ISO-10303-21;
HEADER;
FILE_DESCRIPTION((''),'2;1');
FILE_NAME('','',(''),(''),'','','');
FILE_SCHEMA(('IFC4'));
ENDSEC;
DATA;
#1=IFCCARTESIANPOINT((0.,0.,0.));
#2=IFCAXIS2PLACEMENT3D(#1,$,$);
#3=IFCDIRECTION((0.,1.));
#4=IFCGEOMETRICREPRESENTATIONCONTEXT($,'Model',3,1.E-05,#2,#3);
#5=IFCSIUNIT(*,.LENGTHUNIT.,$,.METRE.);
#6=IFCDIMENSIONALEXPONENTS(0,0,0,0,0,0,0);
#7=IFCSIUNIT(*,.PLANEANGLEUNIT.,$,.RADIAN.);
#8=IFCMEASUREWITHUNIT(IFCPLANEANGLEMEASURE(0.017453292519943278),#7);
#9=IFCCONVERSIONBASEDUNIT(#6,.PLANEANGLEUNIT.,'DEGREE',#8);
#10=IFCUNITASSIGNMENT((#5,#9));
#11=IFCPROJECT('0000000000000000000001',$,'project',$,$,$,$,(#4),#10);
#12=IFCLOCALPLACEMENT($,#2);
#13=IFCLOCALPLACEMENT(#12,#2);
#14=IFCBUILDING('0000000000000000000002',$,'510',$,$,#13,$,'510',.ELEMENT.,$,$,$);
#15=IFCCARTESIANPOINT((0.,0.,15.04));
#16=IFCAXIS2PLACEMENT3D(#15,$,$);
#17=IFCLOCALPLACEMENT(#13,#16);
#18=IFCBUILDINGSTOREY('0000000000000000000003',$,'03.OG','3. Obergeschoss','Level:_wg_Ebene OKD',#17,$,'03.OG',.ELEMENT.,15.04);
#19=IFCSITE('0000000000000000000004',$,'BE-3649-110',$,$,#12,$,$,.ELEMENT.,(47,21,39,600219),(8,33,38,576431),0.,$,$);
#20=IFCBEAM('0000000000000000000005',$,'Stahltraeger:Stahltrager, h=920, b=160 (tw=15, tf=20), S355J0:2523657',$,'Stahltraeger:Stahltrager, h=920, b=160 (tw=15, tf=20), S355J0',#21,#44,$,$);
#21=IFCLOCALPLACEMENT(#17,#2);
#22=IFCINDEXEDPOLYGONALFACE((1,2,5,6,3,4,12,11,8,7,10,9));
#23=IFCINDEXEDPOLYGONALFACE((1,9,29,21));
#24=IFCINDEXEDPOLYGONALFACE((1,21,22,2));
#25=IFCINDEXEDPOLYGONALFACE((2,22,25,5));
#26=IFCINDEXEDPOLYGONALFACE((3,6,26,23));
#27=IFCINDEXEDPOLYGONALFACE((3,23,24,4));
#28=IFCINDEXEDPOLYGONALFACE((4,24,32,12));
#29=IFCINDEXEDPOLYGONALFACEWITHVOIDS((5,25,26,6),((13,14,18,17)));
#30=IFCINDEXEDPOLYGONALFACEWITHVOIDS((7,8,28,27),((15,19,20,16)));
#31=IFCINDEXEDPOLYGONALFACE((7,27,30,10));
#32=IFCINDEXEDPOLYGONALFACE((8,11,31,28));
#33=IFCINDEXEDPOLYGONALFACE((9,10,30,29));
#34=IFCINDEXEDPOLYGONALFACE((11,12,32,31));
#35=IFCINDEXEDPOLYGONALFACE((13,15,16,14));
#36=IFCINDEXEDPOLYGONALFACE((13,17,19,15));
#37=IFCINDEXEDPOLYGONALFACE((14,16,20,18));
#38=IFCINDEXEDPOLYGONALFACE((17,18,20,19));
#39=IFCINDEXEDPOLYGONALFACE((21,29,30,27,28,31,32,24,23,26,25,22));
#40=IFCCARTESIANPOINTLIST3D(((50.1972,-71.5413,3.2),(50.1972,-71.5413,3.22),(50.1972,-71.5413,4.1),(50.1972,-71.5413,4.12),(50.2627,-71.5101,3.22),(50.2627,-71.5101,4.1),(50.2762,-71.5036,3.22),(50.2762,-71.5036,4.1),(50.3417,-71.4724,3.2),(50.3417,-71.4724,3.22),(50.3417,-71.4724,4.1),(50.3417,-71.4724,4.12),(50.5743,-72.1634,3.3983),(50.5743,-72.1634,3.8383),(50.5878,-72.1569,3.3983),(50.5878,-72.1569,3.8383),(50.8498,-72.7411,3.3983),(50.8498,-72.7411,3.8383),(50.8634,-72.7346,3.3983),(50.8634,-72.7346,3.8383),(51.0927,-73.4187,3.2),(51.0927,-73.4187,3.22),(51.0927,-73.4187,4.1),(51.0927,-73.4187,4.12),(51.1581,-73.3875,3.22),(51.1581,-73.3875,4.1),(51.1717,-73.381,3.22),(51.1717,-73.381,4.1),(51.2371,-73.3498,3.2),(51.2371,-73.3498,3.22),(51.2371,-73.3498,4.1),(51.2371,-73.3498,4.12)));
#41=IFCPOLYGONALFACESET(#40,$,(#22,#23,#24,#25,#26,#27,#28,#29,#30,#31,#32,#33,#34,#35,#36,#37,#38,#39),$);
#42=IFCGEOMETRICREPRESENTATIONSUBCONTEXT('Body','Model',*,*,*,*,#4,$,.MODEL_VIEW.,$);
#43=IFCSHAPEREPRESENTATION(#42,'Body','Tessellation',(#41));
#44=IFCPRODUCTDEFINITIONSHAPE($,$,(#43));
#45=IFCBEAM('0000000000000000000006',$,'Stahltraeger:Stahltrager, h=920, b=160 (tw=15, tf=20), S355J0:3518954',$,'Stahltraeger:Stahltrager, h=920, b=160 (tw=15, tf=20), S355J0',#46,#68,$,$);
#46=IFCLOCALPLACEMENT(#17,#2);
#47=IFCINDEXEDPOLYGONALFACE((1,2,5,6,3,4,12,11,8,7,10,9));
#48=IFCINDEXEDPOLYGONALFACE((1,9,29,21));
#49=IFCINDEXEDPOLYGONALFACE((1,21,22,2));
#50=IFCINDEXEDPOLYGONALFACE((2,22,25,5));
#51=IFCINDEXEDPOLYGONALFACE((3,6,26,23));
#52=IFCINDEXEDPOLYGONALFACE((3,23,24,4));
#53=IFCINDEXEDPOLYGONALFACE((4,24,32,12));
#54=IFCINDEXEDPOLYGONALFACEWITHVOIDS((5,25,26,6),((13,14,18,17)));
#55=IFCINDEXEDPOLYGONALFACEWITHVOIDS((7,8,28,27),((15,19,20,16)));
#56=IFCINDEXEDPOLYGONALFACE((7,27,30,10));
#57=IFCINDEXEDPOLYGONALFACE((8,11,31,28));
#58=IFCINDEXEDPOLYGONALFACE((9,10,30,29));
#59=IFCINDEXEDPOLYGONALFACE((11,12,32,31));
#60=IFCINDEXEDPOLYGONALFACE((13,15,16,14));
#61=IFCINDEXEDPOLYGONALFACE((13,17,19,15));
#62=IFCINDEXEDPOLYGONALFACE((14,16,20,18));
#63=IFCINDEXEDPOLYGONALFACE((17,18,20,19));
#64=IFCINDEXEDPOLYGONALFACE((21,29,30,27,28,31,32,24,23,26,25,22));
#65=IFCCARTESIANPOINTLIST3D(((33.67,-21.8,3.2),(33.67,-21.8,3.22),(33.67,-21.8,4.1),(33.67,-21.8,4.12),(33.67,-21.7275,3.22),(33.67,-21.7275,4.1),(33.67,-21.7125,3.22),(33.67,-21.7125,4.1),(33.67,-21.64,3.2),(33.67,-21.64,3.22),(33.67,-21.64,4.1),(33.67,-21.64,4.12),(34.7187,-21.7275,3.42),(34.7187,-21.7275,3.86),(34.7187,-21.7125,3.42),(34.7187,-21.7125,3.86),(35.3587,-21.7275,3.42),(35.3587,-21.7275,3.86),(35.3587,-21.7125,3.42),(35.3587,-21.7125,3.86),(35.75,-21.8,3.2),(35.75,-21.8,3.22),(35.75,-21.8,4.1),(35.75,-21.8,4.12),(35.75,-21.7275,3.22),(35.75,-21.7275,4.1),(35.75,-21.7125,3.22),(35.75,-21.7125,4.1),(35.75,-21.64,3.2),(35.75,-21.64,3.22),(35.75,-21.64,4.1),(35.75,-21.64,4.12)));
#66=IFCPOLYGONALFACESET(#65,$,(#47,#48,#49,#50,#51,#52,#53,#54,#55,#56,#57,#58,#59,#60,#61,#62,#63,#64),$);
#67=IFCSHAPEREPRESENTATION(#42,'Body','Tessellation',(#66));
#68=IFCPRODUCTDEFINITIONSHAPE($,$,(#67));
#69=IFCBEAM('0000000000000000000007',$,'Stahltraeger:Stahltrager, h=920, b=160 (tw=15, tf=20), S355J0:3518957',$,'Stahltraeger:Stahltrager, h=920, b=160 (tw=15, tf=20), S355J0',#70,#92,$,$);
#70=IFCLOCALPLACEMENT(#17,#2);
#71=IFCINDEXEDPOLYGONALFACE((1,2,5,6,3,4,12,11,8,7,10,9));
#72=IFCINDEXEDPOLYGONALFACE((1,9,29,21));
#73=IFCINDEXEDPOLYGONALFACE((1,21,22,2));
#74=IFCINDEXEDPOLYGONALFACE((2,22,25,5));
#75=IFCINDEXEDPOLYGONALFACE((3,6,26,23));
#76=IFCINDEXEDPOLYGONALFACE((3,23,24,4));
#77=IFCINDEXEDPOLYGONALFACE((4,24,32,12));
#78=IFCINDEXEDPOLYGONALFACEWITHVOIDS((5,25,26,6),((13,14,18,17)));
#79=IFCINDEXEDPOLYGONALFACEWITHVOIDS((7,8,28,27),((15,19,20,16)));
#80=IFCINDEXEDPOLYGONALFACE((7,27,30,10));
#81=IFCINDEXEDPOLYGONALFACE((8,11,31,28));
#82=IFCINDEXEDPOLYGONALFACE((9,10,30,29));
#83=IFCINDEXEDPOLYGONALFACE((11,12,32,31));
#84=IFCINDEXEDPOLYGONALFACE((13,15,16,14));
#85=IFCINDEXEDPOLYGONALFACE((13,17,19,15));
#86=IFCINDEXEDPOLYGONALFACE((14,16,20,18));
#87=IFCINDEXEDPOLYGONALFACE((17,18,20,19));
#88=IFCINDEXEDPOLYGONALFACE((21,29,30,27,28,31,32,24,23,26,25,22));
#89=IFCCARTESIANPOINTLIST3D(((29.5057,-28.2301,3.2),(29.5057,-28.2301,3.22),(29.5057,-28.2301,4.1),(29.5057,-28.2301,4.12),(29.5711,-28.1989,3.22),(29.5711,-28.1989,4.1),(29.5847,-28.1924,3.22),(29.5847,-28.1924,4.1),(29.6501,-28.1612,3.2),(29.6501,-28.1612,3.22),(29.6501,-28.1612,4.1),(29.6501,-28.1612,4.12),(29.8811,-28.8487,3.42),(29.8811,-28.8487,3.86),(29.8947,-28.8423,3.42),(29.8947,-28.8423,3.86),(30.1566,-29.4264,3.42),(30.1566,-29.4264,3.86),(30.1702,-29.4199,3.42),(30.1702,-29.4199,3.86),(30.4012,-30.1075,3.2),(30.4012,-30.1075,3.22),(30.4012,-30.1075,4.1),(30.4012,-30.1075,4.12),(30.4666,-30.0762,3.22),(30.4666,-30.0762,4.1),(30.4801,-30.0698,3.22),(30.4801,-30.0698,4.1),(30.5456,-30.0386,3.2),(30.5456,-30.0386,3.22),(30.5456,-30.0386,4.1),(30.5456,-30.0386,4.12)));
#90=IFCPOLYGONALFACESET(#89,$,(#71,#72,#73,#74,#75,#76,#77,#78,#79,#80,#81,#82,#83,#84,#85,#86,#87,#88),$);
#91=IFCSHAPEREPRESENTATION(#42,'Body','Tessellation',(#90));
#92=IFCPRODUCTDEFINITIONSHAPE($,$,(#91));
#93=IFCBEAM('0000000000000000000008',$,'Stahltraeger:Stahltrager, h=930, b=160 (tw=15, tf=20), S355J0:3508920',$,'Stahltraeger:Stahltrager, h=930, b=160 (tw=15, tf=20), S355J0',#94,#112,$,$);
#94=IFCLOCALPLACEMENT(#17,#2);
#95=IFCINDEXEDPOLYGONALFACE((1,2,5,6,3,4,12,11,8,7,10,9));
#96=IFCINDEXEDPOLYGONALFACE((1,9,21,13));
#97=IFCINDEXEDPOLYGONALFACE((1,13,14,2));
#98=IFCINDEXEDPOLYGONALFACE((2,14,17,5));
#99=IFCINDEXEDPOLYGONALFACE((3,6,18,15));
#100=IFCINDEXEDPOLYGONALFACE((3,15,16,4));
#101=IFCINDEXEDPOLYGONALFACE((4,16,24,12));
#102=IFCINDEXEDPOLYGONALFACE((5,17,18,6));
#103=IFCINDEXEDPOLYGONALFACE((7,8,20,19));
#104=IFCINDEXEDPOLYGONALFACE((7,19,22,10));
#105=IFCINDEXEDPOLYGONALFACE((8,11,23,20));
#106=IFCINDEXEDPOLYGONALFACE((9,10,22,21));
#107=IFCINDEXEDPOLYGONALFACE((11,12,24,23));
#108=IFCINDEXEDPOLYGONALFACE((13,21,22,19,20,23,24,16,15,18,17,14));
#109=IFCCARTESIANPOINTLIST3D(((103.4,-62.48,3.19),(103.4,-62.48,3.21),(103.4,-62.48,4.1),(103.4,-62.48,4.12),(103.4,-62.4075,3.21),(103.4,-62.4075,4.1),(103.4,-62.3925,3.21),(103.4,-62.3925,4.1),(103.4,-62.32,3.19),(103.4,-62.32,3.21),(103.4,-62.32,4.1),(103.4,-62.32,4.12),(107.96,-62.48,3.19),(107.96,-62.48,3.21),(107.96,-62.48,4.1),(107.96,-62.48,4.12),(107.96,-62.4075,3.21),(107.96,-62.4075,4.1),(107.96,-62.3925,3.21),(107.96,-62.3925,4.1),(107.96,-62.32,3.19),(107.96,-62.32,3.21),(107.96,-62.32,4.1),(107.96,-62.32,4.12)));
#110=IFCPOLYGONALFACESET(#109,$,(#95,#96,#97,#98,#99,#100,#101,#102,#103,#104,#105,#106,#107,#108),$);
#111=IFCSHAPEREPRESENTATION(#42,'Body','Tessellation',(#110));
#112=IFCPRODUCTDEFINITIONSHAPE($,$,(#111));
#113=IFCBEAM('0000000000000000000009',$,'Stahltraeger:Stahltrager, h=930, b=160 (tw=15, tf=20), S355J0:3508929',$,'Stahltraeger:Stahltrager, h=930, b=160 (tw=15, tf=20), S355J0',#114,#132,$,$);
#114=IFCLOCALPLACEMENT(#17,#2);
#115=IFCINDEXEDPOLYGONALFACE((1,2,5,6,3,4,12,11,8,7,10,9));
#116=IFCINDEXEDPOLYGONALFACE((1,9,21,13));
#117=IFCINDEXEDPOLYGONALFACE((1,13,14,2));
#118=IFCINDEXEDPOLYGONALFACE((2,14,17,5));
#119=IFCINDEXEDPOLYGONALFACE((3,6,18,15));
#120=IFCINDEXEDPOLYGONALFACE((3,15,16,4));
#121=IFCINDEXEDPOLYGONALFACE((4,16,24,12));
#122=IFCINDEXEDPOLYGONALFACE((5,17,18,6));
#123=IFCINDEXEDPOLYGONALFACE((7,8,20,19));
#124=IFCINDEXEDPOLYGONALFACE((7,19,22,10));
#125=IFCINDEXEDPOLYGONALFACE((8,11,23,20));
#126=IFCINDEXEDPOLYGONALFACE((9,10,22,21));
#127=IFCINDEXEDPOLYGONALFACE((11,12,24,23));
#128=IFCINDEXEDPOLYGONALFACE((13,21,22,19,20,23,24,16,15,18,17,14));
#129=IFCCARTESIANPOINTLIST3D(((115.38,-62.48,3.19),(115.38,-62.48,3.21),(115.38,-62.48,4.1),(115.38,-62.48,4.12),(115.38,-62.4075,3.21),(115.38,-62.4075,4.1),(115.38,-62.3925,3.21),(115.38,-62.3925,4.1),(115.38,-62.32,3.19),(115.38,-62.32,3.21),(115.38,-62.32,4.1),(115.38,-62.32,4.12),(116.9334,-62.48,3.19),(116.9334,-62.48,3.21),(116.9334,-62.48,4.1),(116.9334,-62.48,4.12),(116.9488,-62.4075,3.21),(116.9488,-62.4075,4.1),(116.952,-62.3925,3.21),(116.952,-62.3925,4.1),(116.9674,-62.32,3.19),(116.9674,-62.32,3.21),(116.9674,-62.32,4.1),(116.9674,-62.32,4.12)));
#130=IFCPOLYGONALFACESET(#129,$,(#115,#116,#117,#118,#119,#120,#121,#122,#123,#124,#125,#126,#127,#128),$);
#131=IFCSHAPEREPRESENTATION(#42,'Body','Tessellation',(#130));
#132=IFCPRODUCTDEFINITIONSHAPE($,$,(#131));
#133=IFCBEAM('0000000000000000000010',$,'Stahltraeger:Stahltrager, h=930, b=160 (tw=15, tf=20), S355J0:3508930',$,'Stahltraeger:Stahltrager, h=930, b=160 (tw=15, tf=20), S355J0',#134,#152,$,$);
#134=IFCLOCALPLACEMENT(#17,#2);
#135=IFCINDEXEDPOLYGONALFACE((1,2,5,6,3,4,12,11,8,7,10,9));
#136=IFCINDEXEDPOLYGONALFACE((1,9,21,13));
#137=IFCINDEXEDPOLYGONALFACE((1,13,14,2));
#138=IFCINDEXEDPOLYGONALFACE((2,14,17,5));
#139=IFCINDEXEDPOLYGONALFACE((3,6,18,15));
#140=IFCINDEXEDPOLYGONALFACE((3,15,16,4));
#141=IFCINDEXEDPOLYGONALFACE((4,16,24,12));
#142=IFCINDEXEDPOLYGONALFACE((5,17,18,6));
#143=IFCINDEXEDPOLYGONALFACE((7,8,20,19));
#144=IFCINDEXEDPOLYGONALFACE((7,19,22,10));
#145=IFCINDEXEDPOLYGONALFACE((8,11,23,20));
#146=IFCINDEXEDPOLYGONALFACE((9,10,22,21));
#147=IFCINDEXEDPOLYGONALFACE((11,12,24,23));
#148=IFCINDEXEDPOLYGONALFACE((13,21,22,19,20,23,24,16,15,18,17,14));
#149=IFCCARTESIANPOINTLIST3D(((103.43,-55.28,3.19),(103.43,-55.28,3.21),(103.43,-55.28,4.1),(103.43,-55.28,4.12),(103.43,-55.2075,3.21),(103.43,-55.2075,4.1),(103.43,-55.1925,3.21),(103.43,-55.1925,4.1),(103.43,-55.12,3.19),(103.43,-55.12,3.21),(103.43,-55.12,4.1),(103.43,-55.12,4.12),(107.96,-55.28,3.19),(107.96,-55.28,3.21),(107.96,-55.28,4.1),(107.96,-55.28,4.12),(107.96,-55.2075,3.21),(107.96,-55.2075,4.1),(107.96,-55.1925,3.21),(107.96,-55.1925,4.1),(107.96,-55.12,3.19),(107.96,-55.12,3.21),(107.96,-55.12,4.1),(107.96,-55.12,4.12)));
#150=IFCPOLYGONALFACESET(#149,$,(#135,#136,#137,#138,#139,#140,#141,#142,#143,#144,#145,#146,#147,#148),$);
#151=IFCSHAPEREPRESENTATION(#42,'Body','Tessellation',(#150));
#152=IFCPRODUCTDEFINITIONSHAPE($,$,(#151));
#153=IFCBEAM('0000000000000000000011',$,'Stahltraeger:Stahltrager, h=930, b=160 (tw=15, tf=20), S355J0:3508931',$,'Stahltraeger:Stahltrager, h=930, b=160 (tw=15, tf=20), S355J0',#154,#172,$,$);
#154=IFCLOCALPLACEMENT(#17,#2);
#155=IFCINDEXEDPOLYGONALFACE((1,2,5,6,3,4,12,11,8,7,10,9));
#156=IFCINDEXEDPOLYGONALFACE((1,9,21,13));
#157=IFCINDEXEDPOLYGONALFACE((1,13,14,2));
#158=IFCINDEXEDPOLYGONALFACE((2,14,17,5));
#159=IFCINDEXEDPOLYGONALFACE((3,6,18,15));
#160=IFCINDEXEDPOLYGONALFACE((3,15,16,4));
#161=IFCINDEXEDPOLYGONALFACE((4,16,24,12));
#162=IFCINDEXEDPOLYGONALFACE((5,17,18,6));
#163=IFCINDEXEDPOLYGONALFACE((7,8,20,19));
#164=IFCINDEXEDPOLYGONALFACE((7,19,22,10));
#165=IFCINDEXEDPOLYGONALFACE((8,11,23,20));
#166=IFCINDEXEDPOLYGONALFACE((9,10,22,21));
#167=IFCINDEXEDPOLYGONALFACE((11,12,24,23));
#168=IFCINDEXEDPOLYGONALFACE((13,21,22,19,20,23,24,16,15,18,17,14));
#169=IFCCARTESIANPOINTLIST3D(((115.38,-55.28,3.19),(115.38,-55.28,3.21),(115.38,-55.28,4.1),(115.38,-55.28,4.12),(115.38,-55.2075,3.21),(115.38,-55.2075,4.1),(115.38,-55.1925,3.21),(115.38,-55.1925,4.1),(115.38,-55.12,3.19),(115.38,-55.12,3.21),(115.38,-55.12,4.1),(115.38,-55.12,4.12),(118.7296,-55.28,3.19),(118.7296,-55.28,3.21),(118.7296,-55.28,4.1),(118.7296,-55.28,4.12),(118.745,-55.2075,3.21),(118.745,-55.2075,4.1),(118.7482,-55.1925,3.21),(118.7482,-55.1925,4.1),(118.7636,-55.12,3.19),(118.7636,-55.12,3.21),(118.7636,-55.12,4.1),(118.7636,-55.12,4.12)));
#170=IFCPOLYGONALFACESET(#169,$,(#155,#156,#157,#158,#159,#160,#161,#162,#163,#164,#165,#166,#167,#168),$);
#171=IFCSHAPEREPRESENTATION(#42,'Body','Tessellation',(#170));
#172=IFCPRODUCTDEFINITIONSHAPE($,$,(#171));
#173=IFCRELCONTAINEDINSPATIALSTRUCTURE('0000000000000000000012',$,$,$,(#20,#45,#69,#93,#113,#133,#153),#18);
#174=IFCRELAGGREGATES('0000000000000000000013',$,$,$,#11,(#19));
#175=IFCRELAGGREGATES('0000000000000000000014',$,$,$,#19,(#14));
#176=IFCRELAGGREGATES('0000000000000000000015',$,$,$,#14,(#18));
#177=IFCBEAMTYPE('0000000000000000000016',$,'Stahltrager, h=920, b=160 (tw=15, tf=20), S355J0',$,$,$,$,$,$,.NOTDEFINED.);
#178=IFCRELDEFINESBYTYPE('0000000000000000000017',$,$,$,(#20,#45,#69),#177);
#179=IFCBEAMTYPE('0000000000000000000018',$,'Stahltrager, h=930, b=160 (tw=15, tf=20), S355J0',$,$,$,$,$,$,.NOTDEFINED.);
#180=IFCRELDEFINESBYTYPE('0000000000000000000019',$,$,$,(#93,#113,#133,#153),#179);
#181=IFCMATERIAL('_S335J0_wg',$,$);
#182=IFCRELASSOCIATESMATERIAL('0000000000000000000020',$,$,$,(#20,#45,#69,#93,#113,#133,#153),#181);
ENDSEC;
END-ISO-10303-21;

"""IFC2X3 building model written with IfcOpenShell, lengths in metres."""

from ifc_helpers import new_model, entity, si_unit, converted_unit, direction, frame, frame_2d, origin, place, context, subcontext, project, spatial, polyline, rectangle, i_section, outline, extrude, boolean, clip, halfspace, material, type_object, element, save


model = new_model("IFC2X3")

# Units and contexts
model_context = context("Model", 3, precision=1e-05, world=origin(), true_north=direction((0.0, 1.0)))
body_context = subcontext(model_context, "Body", "Model", "MODEL_VIEW")
ifc_project = project(units=[si_unit("LENGTHUNIT", "METRE"), converted_unit("PLANEANGLEUNIT", "DEGREE", entity("IfcPlaneAngleMeasure", 0.017453292519943278), si_unit("PLANEANGLEUNIT", "RADIAN"), dimensions=[0, 0, 0, 0, 0, 0, 0])], contexts=[model_context])

# Site, building, storey
site_placement = place(None, origin())
site = spatial("IfcSite", under=ifc_project, at=site_placement, Name="BE-3649-110", CompositionType="ELEMENT", RefLatitude=(47, 21, 39, 600219), RefLongitude=(8, 33, 38, 576431), RefElevation=0.0)
building_placement = place(site_placement, origin())
building = spatial("IfcBuilding", under=site, at=building_placement, Name="510", LongName="510", CompositionType="ELEMENT")
storey_placement = place(building_placement, frame((0.0, 0.0, 15.04)))
storey = spatial("IfcBuildingStorey", under=building, at=storey_placement, Name="03.OG", Description="3. Obergeschoss", ObjectType="Level:_wg_Ebene OKD", LongName="03.OG", CompositionType="ELEMENT", Elevation=15.04)

# Beams
ifc_material_1 = material(Name="_S335J0_wg")
beam_type_1 = type_object("IfcBeamType", Name="Stahltrager, h=920, b=160 (tw=15, tf=20), S355J0", PredefinedType="NOTDEFINED")
beam_1_placement = place(storey_placement, frame((50.2695, -71.5068, 4.12), z_axis=(0.0, 0.0, 1.0), x_axis=(0.430511, -0.902585, 0.0)))
element("IfcBeam", 1, at=beam_1_placement, inside=storey, type_object=beam_type_1, material=ifc_material_1, Name="Stahltraeger:Stahltrager, h=920, b=160 (tw=15, tf=20), S355J0:2523657", ObjectType="Stahltraeger:Stahltrager, h=920, b=160 (tw=15, tf=20), S355J0", context=body_context, shape_type="SweptSolid", body=[
    boolean("DIFFERENCE", extrude(i_section(OverallWidth=0.16, OverallDepth=0.92, WebThickness=0.015, FlangeThickness=0.02, at=frame_2d((0.0, 0.0), x_axis=(0.0, 1.0))), frame((0.0, 0.0, -0.46), z_axis=(1.0, 0.0, 0.0), x_axis=(0.0, 0.0, -1.0)), (0.0, 0.0, 1.0), 2.08), extrude(rectangle(XDim=0.44, YDim=0.64, at=frame_2d((0.0, 0.0), x_axis=(0.0, 1.0))), frame((1.0438, 0.0075, -0.5017), z_axis=(0.0, -1.0, 0.0), x_axis=(-1.0, 0.0, 0.0)), (0.0, 0.0, 1.0), 0.015)),
])
beam_2_placement = place(storey_placement, frame((33.67, -21.72, 4.12)))
element("IfcBeam", 2, at=beam_2_placement, inside=storey, type_object=beam_type_1, material=ifc_material_1, Name="Stahltraeger:Stahltrager, h=920, b=160 (tw=15, tf=20), S355J0:3518954", ObjectType="Stahltraeger:Stahltrager, h=920, b=160 (tw=15, tf=20), S355J0", context=body_context, shape_type="SweptSolid", body=[
    boolean("DIFFERENCE", extrude(i_section(OverallWidth=0.16, OverallDepth=0.92, WebThickness=0.015, FlangeThickness=0.02, at=frame_2d((0.0, 0.0), x_axis=(0.0, 1.0))), frame((0.0, 0.0, -0.46), z_axis=(1.0, 0.0, 0.0), x_axis=(0.0, 0.0, -1.0)), (0.0, 0.0, 1.0), 2.08), extrude(rectangle(XDim=0.44, YDim=0.64, at=frame_2d((0.0, 0.0), x_axis=(0.0, 1.0))), frame((1.3687, 0.0075, -0.48), z_axis=(0.0, -1.0, 0.0), x_axis=(-1.0, 0.0, 0.0)), (0.0, 0.0, 1.0), 0.015)),
])
beam_3_placement = place(storey_placement, frame((30.4734, -30.073, 4.12), z_axis=(0.0, 0.0, 1.0), x_axis=(-0.430511, 0.902585, 0.0)))
element("IfcBeam", 3, at=beam_3_placement, inside=storey, type_object=beam_type_1, material=ifc_material_1, Name="Stahltraeger:Stahltrager, h=920, b=160 (tw=15, tf=20), S355J0:3518957", ObjectType="Stahltraeger:Stahltrager, h=920, b=160 (tw=15, tf=20), S355J0", context=body_context, shape_type="SweptSolid", body=[
    boolean("DIFFERENCE", extrude(i_section(OverallWidth=0.16, OverallDepth=0.92, WebThickness=0.015, FlangeThickness=0.02, at=frame_2d((0.0, 0.0), x_axis=(0.0, 1.0))), frame((0.0, 0.0, -0.46), z_axis=(1.0, 0.0, 0.0), x_axis=(0.0, 0.0, -1.0)), (0.0, 0.0, 1.0), 2.08), extrude(rectangle(XDim=0.44, YDim=0.64, at=frame_2d((0.0, 0.0), x_axis=(0.0, 1.0))), frame((1.04, 0.0075, -0.48), z_axis=(0.0, -1.0, 0.0), x_axis=(-1.0, 0.0, 0.0)), (0.0, 0.0, 1.0), 0.015)),
])
beam_type_2 = type_object("IfcBeamType", Name="Stahltrager, h=930, b=160 (tw=15, tf=20), S355J0", PredefinedType="NOTDEFINED")
beam_4_placement = place(storey_placement, frame((103.4, -62.48, 3.19)))
element("IfcBeam", 4, at=beam_4_placement, inside=storey, type_object=beam_type_2, material=ifc_material_1, Name="Stahltraeger:Stahltrager, h=930, b=160 (tw=15, tf=20), S355J0:3508920", ObjectType="Stahltraeger:Stahltrager, h=930, b=160 (tw=15, tf=20), S355J0", context=body_context, shape_type="SweptSolid", body=[
    extrude(outline(polyline([(-0.08, -0.445), (-0.08, -0.465), (0.08, -0.465), (0.08, -0.445), (0.0075, -0.445), (0.0075, 0.445), (0.08, 0.445), (0.08, 0.465), (-0.08, 0.465), (-0.08, 0.445), (-0.0075, 0.445), (-0.0075, -0.445), (-0.08, -0.445)])), frame((0.0, 0.08, 0.465), z_axis=(-1.0, 0.0, 0.0), x_axis=(0.0, -1.0, 0.0)), (0.0, 0.0, -1.0), 4.56),
])
beam_5_placement = place(storey_placement, frame((115.38, -62.4, 4.12)))
element("IfcBeam", 5, at=beam_5_placement, inside=storey, type_object=beam_type_2, material=ifc_material_1, Name="Stahltraeger:Stahltrager, h=930, b=160 (tw=15, tf=20), S355J0:3508929", ObjectType="Stahltraeger:Stahltrager, h=930, b=160 (tw=15, tf=20), S355J0", context=body_context, shape_type="SweptSolid", body=[
    clip(extrude(i_section(OverallWidth=0.16, OverallDepth=0.93, WebThickness=0.015, FlangeThickness=0.02, at=frame_2d((0.0, 0.0), x_axis=(0.0, 1.0))), frame((0.0, 0.0, -0.465), z_axis=(1.0, 0.0, 0.0), x_axis=(0.0, 0.0, -1.0)), (0.0, 0.0, 1.0), 1.5873), halfspace(frame((1.4983, -0.3393, 5.62), z_axis=(0.978148, -0.207912, 0.0), x_axis=(0.207912, 0.978148, 0.0)), False)),
])
beam_6_placement = place(storey_placement, frame((103.43, -55.28, 3.19)))
element("IfcBeam", 6, at=beam_6_placement, inside=storey, type_object=beam_type_2, material=ifc_material_1, Name="Stahltraeger:Stahltrager, h=930, b=160 (tw=15, tf=20), S355J0:3508930", ObjectType="Stahltraeger:Stahltrager, h=930, b=160 (tw=15, tf=20), S355J0", context=body_context, shape_type="SweptSolid", body=[
    extrude(outline(polyline([(-0.08, -0.445), (-0.08, -0.465), (0.08, -0.465), (0.08, -0.445), (0.0075, -0.445), (0.0075, 0.445), (0.08, 0.445), (0.08, 0.465), (-0.08, 0.465), (-0.08, 0.445), (-0.0075, 0.445), (-0.0075, -0.445), (-0.08, -0.445)])), frame((0.0, 0.08, 0.465), z_axis=(-1.0, 0.0, 0.0), x_axis=(0.0, -1.0, 0.0)), (0.0, 0.0, -1.0), 4.53),
])
beam_7_placement = place(storey_placement, frame((115.38, -55.2, 4.12)))
element("IfcBeam", 7, at=beam_7_placement, inside=storey, type_object=beam_type_2, material=ifc_material_1, Name="Stahltraeger:Stahltrager, h=930, b=160 (tw=15, tf=20), S355J0:3508931", ObjectType="Stahltraeger:Stahltrager, h=930, b=160 (tw=15, tf=20), S355J0", context=body_context, shape_type="SweptSolid", body=[
    clip(extrude(i_section(OverallWidth=0.16, OverallDepth=0.93, WebThickness=0.015, FlangeThickness=0.02, at=frame_2d((0.0, 0.0), x_axis=(0.0, 1.0))), frame((0.0, 0.0, -0.465), z_axis=(1.0, 0.0, 0.0), x_axis=(0.0, 0.0, -1.0)), (0.0, 0.0, 1.0), 3.3836), halfspace(frame((3.2599, -0.5018, 5.62), z_axis=(0.978148, -0.207912, 0.0), x_axis=(0.207912, 0.978148, 0.0)), False)),
])

save(model, "model.ifc")
